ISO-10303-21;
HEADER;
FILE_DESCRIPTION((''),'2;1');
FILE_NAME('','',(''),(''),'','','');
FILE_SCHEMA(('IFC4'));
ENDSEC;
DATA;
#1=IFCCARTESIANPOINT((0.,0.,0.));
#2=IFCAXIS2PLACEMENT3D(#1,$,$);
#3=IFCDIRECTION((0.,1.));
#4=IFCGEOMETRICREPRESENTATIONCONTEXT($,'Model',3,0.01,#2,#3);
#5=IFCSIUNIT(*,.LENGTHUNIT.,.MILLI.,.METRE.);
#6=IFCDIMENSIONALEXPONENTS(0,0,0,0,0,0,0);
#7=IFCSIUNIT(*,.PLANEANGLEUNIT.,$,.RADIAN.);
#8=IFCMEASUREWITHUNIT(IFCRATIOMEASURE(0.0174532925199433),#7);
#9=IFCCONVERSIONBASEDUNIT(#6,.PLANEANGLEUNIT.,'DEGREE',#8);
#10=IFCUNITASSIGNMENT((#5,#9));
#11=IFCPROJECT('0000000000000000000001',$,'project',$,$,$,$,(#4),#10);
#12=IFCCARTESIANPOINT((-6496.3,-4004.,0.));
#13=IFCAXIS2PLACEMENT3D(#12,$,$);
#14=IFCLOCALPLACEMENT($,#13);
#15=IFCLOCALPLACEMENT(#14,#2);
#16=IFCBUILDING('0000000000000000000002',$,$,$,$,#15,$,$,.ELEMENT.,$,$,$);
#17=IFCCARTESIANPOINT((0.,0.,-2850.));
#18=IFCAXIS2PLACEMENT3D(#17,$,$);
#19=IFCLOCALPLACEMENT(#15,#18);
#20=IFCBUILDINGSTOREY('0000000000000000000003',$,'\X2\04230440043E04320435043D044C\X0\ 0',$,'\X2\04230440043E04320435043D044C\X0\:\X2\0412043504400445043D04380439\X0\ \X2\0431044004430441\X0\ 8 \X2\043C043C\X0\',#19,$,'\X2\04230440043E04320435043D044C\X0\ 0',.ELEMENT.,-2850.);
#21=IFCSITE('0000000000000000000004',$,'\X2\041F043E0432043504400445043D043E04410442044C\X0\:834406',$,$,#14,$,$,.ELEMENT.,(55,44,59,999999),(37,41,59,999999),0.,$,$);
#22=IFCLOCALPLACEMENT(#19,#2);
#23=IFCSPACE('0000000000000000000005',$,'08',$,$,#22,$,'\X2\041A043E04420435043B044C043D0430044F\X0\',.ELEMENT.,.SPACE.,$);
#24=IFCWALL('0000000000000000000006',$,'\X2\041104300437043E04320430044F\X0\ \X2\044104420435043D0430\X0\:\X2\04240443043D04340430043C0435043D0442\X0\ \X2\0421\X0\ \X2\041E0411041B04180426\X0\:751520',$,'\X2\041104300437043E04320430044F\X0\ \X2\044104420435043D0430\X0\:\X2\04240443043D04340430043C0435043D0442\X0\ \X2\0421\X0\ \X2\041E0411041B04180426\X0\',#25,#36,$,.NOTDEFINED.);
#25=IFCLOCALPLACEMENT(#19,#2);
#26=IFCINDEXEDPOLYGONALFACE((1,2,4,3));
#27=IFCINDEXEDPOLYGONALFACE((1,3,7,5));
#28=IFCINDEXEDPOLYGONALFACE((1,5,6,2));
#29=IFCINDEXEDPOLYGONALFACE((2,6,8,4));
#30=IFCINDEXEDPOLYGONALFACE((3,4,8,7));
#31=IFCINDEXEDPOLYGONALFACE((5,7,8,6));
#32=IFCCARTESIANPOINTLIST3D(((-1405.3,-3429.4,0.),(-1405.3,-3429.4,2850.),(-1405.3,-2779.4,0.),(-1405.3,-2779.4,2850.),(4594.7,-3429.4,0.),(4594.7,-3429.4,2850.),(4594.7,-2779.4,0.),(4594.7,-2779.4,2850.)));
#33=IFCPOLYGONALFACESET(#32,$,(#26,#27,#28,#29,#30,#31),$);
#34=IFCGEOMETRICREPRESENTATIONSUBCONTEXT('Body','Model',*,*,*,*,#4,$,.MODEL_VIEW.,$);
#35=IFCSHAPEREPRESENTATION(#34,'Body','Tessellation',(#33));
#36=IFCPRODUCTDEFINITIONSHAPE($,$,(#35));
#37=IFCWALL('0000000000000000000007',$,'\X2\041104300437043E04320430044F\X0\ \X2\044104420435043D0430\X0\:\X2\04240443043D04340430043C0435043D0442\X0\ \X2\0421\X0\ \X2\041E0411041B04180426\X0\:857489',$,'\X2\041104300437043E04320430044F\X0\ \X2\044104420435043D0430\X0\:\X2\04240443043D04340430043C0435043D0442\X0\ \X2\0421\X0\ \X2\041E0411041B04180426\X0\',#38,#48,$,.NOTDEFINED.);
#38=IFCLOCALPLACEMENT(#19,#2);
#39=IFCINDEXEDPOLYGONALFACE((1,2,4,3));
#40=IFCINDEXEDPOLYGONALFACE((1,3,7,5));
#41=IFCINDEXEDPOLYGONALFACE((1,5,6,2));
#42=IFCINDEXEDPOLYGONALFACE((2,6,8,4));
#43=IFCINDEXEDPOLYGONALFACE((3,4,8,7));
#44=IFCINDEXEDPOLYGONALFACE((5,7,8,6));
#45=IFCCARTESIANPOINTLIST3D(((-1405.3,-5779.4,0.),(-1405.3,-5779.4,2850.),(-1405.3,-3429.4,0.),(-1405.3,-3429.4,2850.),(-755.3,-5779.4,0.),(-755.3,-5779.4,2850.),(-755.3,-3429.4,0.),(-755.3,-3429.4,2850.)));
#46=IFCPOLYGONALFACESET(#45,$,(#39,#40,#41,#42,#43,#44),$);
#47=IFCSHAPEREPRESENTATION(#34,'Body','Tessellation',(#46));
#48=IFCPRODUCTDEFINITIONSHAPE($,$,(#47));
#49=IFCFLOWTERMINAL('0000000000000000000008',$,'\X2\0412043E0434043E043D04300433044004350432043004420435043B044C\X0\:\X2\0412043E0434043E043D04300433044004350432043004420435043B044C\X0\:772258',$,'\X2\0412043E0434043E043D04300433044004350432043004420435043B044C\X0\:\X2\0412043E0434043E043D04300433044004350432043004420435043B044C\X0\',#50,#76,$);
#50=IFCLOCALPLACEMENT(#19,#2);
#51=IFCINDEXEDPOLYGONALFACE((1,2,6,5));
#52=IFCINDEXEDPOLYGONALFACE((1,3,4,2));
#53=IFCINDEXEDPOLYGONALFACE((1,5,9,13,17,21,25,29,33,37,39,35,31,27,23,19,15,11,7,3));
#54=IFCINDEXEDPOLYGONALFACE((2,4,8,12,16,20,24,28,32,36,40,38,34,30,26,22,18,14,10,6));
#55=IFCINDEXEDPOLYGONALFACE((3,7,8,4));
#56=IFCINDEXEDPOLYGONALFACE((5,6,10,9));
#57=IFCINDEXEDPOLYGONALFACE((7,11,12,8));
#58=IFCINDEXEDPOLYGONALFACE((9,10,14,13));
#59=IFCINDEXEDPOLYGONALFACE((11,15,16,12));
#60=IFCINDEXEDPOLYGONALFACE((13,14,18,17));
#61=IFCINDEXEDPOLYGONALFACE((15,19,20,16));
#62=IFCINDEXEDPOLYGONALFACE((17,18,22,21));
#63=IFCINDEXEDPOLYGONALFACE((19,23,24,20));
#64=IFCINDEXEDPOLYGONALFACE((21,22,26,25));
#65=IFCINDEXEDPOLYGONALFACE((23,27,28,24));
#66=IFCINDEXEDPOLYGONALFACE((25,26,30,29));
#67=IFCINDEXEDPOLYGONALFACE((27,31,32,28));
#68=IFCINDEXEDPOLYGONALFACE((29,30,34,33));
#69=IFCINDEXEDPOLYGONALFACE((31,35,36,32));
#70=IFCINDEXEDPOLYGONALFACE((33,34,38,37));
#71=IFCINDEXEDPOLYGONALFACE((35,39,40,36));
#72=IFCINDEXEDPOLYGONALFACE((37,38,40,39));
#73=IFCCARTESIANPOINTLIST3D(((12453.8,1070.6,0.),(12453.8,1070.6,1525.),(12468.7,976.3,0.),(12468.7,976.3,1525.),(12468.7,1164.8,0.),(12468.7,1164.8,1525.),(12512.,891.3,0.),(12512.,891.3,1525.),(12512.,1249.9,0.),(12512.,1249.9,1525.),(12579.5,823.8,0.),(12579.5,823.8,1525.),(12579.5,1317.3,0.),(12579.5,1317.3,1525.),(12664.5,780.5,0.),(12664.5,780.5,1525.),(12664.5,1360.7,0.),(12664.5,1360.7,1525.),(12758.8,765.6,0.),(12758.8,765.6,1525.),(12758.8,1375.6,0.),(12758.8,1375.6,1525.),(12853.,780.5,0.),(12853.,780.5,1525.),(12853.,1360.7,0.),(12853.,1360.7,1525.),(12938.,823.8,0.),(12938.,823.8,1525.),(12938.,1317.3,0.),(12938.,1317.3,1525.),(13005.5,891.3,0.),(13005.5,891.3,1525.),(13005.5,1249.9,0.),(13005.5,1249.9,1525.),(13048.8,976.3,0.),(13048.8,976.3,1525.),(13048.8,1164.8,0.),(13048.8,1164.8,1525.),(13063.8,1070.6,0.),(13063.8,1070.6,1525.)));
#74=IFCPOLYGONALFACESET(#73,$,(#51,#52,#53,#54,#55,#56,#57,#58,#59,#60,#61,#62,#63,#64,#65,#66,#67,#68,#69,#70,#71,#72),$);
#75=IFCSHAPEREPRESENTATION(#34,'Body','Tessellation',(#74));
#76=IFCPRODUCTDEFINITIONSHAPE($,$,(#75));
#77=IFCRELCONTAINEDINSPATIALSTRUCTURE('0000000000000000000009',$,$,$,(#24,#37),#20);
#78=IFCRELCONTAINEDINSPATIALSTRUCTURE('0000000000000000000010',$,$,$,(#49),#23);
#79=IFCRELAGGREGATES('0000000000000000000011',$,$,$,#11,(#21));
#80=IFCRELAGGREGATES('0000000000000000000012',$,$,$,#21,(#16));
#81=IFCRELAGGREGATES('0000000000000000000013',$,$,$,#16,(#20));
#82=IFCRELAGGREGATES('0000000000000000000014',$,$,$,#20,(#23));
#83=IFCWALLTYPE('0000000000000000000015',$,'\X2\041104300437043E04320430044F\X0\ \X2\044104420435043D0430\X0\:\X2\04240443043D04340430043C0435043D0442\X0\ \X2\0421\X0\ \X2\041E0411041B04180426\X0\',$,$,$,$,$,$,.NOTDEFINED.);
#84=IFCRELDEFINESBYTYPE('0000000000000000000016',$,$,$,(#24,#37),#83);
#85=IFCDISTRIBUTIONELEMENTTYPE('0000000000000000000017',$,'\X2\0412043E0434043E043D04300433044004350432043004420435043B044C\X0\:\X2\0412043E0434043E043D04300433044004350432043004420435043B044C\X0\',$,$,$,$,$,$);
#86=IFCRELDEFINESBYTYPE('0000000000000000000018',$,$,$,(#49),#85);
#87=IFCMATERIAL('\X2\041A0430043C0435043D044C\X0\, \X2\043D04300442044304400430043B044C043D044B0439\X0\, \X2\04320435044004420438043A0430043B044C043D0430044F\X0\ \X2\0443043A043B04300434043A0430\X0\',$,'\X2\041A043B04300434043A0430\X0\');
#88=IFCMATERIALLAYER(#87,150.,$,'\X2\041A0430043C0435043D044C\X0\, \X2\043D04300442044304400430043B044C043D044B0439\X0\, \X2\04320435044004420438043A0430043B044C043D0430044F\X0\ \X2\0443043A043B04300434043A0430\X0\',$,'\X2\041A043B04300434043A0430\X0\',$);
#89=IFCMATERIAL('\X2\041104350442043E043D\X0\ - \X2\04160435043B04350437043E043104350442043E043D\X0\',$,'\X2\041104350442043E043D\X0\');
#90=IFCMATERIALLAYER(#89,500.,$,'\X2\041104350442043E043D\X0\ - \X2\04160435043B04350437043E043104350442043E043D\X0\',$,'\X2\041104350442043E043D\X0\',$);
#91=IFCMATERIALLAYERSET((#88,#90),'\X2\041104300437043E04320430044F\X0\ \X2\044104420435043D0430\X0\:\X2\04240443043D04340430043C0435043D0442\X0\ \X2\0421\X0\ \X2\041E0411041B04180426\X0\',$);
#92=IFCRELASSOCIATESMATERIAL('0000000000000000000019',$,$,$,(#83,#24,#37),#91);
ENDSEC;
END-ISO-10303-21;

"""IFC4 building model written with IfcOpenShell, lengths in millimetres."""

from ifc_helpers import new_model, entity, si_unit, converted_unit, direction, frame, origin, place, context, subcontext, project, spatial, indexed_curve, outline, extrude, source, transform, mapped, material, layer, layer_set, type_object, type_shapes, element, save


model = new_model("IFC4")

# Units and contexts
model_context = context("Model", 3, precision=0.01, world=origin(), true_north=direction((0.0, 1.0)))
body_context = subcontext(model_context, "Body", "Model", "MODEL_VIEW")
ifc_project = project(units=[si_unit("LENGTHUNIT", "METRE", prefix="MILLI"), converted_unit("PLANEANGLEUNIT", "DEGREE", entity("IfcRatioMeasure", 0.0174532925199433), si_unit("PLANEANGLEUNIT", "RADIAN"), dimensions=[0, 0, 0, 0, 0, 0, 0])], contexts=[model_context])

# Site, building, storey
site_placement = place(None, frame((-6496.3, -4004.0, 0.0)))
site = spatial("IfcSite", under=ifc_project, at=site_placement, Name="Поверхность:834406", CompositionType="ELEMENT", RefLatitude=(55, 44, 59, 999999), RefLongitude=(37, 41, 59, 999999), RefElevation=0.0)
building_placement = place(site_placement, origin())
building = spatial("IfcBuilding", under=site, at=building_placement, CompositionType="ELEMENT")
storey_placement = place(building_placement, frame((0.0, 0.0, -2850.0)))
storey = spatial("IfcBuildingStorey", under=building, at=storey_placement, Name="Уровень 0", ObjectType="Уровень:Верхний брус 8 мм", LongName="Уровень 0", CompositionType="ELEMENT", Elevation=-2850.0)

# Shared definitions
ifc_material_1 = material(Name="Бетон - Железобетон", Category="Бетон")

# Walls
ifc_material_2 = material(Name="Камень, натуральный, вертикальная укладка", Category="Кладка")
ifc_layer_1 = layer(ifc_material_2, 150.0, Name="Камень, натуральный, вертикальная укладка", Category="Кладка")
ifc_layer_2 = layer(ifc_material_1, 500.0, Name="Бетон - Железобетон", Category="Бетон")
ifc_layer_set_1 = layer_set([ifc_layer_1, ifc_layer_2], Name="Базовая стена:Фундамент С ОБЛИЦ")
wall_type_1 = type_object("IfcWallType", Name="Базовая стена:Фундамент С ОБЛИЦ", PredefinedType="NOTDEFINED", material=ifc_layer_set_1)
wall_1_placement = place(storey_placement, frame((4594.7, -3104.4, 0.0), z_axis=(0.0, 0.0, 1.0), x_axis=(-1.0, 0.0, 0.0)))
element("IfcWall", 1, at=wall_1_placement, inside=storey, type_object=wall_type_1, material=ifc_layer_set_1, Name="Базовая стена:Фундамент С ОБЛИЦ:751520", ObjectType="Базовая стена:Фундамент С ОБЛИЦ", PredefinedType="NOTDEFINED", context=body_context, shape_type="SweptSolid", body=[
    extrude(outline(indexed_curve([(6000.0, 325.0), (0.0, 325.0), (0.0, -325.0), (6000.0, -325.0), (6000.0, 325.0)], self_intersect=False)), origin(), (0.0, 0.0, 1.0), 2850.0),
])
wall_2_placement = place(storey_placement, frame((-1080.3, -3429.4, 0.0), z_axis=(0.0, 0.0, 1.0), x_axis=(0.0, -1.0, 0.0)))
element("IfcWall", 2, at=wall_2_placement, inside=storey, type_object=wall_type_1, material=ifc_layer_set_1, Name="Базовая стена:Фундамент С ОБЛИЦ:857489", ObjectType="Базовая стена:Фундамент С ОБЛИЦ", PredefinedType="NOTDEFINED", context=body_context, shape_type="SweptSolid", body=[
    extrude(outline(indexed_curve([(2350.0, 325.0), (0.0, 325.0), (0.0, -325.0), (2350.0, -325.0), (2350.0, 325.0)], self_intersect=False)), origin(), (0.0, 0.0, 1.0), 2850.0),
])

# Shared definitions
space_placement = place(storey_placement, origin())
space = spatial("IfcSpace", under=storey, at=space_placement, Name="08", LongName="Котельная", CompositionType="ELEMENT", PredefinedType="SPACE")

# Flow terminal
distribution_element_type = type_object("IfcDistributionElementType", Name="Водонагреватель:Водонагреватель")
shared_shape = source(origin(), body_context, "Body", "SweptSolid", [
    extrude(outline(indexed_curve([(305.0, 0.0), (290.1, 94.3), (246.8, 179.3), (179.3, 246.8), (94.3, 290.1), (0.0, 305.0), (-94.3, 290.1), (-179.3, 246.8), (-246.8, 179.3), (-290.1, 94.3), (-305.0, 0.0), (-290.1, -94.3), (-246.8, -179.3), (-179.3, -246.8), (-94.3, -290.1), (0.0, -305.0), (94.3, -290.1), (179.3, -246.8), (246.8, -179.3), (290.1, -94.3), (305.0, 0.0)], self_intersect=False)), origin(), (0.0, 0.0, 1.0), 1525.0),
])
type_shapes(distribution_element_type, [shared_shape])
flow_terminal_placement = place(space_placement, frame((12758.8, 1070.6, 0.0)))
element("IfcFlowTerminal", 3, at=flow_terminal_placement, inside=space, type_object=distribution_element_type, Name="Водонагреватель:Водонагреватель:772258", ObjectType="Водонагреватель:Водонагреватель", context=body_context, shape_type="MappedRepresentation", body=[
    mapped(shared_shape, transform((0.0, 0.0, 0.0), scale=1.0)),
])

save(model, "model.ifc")
